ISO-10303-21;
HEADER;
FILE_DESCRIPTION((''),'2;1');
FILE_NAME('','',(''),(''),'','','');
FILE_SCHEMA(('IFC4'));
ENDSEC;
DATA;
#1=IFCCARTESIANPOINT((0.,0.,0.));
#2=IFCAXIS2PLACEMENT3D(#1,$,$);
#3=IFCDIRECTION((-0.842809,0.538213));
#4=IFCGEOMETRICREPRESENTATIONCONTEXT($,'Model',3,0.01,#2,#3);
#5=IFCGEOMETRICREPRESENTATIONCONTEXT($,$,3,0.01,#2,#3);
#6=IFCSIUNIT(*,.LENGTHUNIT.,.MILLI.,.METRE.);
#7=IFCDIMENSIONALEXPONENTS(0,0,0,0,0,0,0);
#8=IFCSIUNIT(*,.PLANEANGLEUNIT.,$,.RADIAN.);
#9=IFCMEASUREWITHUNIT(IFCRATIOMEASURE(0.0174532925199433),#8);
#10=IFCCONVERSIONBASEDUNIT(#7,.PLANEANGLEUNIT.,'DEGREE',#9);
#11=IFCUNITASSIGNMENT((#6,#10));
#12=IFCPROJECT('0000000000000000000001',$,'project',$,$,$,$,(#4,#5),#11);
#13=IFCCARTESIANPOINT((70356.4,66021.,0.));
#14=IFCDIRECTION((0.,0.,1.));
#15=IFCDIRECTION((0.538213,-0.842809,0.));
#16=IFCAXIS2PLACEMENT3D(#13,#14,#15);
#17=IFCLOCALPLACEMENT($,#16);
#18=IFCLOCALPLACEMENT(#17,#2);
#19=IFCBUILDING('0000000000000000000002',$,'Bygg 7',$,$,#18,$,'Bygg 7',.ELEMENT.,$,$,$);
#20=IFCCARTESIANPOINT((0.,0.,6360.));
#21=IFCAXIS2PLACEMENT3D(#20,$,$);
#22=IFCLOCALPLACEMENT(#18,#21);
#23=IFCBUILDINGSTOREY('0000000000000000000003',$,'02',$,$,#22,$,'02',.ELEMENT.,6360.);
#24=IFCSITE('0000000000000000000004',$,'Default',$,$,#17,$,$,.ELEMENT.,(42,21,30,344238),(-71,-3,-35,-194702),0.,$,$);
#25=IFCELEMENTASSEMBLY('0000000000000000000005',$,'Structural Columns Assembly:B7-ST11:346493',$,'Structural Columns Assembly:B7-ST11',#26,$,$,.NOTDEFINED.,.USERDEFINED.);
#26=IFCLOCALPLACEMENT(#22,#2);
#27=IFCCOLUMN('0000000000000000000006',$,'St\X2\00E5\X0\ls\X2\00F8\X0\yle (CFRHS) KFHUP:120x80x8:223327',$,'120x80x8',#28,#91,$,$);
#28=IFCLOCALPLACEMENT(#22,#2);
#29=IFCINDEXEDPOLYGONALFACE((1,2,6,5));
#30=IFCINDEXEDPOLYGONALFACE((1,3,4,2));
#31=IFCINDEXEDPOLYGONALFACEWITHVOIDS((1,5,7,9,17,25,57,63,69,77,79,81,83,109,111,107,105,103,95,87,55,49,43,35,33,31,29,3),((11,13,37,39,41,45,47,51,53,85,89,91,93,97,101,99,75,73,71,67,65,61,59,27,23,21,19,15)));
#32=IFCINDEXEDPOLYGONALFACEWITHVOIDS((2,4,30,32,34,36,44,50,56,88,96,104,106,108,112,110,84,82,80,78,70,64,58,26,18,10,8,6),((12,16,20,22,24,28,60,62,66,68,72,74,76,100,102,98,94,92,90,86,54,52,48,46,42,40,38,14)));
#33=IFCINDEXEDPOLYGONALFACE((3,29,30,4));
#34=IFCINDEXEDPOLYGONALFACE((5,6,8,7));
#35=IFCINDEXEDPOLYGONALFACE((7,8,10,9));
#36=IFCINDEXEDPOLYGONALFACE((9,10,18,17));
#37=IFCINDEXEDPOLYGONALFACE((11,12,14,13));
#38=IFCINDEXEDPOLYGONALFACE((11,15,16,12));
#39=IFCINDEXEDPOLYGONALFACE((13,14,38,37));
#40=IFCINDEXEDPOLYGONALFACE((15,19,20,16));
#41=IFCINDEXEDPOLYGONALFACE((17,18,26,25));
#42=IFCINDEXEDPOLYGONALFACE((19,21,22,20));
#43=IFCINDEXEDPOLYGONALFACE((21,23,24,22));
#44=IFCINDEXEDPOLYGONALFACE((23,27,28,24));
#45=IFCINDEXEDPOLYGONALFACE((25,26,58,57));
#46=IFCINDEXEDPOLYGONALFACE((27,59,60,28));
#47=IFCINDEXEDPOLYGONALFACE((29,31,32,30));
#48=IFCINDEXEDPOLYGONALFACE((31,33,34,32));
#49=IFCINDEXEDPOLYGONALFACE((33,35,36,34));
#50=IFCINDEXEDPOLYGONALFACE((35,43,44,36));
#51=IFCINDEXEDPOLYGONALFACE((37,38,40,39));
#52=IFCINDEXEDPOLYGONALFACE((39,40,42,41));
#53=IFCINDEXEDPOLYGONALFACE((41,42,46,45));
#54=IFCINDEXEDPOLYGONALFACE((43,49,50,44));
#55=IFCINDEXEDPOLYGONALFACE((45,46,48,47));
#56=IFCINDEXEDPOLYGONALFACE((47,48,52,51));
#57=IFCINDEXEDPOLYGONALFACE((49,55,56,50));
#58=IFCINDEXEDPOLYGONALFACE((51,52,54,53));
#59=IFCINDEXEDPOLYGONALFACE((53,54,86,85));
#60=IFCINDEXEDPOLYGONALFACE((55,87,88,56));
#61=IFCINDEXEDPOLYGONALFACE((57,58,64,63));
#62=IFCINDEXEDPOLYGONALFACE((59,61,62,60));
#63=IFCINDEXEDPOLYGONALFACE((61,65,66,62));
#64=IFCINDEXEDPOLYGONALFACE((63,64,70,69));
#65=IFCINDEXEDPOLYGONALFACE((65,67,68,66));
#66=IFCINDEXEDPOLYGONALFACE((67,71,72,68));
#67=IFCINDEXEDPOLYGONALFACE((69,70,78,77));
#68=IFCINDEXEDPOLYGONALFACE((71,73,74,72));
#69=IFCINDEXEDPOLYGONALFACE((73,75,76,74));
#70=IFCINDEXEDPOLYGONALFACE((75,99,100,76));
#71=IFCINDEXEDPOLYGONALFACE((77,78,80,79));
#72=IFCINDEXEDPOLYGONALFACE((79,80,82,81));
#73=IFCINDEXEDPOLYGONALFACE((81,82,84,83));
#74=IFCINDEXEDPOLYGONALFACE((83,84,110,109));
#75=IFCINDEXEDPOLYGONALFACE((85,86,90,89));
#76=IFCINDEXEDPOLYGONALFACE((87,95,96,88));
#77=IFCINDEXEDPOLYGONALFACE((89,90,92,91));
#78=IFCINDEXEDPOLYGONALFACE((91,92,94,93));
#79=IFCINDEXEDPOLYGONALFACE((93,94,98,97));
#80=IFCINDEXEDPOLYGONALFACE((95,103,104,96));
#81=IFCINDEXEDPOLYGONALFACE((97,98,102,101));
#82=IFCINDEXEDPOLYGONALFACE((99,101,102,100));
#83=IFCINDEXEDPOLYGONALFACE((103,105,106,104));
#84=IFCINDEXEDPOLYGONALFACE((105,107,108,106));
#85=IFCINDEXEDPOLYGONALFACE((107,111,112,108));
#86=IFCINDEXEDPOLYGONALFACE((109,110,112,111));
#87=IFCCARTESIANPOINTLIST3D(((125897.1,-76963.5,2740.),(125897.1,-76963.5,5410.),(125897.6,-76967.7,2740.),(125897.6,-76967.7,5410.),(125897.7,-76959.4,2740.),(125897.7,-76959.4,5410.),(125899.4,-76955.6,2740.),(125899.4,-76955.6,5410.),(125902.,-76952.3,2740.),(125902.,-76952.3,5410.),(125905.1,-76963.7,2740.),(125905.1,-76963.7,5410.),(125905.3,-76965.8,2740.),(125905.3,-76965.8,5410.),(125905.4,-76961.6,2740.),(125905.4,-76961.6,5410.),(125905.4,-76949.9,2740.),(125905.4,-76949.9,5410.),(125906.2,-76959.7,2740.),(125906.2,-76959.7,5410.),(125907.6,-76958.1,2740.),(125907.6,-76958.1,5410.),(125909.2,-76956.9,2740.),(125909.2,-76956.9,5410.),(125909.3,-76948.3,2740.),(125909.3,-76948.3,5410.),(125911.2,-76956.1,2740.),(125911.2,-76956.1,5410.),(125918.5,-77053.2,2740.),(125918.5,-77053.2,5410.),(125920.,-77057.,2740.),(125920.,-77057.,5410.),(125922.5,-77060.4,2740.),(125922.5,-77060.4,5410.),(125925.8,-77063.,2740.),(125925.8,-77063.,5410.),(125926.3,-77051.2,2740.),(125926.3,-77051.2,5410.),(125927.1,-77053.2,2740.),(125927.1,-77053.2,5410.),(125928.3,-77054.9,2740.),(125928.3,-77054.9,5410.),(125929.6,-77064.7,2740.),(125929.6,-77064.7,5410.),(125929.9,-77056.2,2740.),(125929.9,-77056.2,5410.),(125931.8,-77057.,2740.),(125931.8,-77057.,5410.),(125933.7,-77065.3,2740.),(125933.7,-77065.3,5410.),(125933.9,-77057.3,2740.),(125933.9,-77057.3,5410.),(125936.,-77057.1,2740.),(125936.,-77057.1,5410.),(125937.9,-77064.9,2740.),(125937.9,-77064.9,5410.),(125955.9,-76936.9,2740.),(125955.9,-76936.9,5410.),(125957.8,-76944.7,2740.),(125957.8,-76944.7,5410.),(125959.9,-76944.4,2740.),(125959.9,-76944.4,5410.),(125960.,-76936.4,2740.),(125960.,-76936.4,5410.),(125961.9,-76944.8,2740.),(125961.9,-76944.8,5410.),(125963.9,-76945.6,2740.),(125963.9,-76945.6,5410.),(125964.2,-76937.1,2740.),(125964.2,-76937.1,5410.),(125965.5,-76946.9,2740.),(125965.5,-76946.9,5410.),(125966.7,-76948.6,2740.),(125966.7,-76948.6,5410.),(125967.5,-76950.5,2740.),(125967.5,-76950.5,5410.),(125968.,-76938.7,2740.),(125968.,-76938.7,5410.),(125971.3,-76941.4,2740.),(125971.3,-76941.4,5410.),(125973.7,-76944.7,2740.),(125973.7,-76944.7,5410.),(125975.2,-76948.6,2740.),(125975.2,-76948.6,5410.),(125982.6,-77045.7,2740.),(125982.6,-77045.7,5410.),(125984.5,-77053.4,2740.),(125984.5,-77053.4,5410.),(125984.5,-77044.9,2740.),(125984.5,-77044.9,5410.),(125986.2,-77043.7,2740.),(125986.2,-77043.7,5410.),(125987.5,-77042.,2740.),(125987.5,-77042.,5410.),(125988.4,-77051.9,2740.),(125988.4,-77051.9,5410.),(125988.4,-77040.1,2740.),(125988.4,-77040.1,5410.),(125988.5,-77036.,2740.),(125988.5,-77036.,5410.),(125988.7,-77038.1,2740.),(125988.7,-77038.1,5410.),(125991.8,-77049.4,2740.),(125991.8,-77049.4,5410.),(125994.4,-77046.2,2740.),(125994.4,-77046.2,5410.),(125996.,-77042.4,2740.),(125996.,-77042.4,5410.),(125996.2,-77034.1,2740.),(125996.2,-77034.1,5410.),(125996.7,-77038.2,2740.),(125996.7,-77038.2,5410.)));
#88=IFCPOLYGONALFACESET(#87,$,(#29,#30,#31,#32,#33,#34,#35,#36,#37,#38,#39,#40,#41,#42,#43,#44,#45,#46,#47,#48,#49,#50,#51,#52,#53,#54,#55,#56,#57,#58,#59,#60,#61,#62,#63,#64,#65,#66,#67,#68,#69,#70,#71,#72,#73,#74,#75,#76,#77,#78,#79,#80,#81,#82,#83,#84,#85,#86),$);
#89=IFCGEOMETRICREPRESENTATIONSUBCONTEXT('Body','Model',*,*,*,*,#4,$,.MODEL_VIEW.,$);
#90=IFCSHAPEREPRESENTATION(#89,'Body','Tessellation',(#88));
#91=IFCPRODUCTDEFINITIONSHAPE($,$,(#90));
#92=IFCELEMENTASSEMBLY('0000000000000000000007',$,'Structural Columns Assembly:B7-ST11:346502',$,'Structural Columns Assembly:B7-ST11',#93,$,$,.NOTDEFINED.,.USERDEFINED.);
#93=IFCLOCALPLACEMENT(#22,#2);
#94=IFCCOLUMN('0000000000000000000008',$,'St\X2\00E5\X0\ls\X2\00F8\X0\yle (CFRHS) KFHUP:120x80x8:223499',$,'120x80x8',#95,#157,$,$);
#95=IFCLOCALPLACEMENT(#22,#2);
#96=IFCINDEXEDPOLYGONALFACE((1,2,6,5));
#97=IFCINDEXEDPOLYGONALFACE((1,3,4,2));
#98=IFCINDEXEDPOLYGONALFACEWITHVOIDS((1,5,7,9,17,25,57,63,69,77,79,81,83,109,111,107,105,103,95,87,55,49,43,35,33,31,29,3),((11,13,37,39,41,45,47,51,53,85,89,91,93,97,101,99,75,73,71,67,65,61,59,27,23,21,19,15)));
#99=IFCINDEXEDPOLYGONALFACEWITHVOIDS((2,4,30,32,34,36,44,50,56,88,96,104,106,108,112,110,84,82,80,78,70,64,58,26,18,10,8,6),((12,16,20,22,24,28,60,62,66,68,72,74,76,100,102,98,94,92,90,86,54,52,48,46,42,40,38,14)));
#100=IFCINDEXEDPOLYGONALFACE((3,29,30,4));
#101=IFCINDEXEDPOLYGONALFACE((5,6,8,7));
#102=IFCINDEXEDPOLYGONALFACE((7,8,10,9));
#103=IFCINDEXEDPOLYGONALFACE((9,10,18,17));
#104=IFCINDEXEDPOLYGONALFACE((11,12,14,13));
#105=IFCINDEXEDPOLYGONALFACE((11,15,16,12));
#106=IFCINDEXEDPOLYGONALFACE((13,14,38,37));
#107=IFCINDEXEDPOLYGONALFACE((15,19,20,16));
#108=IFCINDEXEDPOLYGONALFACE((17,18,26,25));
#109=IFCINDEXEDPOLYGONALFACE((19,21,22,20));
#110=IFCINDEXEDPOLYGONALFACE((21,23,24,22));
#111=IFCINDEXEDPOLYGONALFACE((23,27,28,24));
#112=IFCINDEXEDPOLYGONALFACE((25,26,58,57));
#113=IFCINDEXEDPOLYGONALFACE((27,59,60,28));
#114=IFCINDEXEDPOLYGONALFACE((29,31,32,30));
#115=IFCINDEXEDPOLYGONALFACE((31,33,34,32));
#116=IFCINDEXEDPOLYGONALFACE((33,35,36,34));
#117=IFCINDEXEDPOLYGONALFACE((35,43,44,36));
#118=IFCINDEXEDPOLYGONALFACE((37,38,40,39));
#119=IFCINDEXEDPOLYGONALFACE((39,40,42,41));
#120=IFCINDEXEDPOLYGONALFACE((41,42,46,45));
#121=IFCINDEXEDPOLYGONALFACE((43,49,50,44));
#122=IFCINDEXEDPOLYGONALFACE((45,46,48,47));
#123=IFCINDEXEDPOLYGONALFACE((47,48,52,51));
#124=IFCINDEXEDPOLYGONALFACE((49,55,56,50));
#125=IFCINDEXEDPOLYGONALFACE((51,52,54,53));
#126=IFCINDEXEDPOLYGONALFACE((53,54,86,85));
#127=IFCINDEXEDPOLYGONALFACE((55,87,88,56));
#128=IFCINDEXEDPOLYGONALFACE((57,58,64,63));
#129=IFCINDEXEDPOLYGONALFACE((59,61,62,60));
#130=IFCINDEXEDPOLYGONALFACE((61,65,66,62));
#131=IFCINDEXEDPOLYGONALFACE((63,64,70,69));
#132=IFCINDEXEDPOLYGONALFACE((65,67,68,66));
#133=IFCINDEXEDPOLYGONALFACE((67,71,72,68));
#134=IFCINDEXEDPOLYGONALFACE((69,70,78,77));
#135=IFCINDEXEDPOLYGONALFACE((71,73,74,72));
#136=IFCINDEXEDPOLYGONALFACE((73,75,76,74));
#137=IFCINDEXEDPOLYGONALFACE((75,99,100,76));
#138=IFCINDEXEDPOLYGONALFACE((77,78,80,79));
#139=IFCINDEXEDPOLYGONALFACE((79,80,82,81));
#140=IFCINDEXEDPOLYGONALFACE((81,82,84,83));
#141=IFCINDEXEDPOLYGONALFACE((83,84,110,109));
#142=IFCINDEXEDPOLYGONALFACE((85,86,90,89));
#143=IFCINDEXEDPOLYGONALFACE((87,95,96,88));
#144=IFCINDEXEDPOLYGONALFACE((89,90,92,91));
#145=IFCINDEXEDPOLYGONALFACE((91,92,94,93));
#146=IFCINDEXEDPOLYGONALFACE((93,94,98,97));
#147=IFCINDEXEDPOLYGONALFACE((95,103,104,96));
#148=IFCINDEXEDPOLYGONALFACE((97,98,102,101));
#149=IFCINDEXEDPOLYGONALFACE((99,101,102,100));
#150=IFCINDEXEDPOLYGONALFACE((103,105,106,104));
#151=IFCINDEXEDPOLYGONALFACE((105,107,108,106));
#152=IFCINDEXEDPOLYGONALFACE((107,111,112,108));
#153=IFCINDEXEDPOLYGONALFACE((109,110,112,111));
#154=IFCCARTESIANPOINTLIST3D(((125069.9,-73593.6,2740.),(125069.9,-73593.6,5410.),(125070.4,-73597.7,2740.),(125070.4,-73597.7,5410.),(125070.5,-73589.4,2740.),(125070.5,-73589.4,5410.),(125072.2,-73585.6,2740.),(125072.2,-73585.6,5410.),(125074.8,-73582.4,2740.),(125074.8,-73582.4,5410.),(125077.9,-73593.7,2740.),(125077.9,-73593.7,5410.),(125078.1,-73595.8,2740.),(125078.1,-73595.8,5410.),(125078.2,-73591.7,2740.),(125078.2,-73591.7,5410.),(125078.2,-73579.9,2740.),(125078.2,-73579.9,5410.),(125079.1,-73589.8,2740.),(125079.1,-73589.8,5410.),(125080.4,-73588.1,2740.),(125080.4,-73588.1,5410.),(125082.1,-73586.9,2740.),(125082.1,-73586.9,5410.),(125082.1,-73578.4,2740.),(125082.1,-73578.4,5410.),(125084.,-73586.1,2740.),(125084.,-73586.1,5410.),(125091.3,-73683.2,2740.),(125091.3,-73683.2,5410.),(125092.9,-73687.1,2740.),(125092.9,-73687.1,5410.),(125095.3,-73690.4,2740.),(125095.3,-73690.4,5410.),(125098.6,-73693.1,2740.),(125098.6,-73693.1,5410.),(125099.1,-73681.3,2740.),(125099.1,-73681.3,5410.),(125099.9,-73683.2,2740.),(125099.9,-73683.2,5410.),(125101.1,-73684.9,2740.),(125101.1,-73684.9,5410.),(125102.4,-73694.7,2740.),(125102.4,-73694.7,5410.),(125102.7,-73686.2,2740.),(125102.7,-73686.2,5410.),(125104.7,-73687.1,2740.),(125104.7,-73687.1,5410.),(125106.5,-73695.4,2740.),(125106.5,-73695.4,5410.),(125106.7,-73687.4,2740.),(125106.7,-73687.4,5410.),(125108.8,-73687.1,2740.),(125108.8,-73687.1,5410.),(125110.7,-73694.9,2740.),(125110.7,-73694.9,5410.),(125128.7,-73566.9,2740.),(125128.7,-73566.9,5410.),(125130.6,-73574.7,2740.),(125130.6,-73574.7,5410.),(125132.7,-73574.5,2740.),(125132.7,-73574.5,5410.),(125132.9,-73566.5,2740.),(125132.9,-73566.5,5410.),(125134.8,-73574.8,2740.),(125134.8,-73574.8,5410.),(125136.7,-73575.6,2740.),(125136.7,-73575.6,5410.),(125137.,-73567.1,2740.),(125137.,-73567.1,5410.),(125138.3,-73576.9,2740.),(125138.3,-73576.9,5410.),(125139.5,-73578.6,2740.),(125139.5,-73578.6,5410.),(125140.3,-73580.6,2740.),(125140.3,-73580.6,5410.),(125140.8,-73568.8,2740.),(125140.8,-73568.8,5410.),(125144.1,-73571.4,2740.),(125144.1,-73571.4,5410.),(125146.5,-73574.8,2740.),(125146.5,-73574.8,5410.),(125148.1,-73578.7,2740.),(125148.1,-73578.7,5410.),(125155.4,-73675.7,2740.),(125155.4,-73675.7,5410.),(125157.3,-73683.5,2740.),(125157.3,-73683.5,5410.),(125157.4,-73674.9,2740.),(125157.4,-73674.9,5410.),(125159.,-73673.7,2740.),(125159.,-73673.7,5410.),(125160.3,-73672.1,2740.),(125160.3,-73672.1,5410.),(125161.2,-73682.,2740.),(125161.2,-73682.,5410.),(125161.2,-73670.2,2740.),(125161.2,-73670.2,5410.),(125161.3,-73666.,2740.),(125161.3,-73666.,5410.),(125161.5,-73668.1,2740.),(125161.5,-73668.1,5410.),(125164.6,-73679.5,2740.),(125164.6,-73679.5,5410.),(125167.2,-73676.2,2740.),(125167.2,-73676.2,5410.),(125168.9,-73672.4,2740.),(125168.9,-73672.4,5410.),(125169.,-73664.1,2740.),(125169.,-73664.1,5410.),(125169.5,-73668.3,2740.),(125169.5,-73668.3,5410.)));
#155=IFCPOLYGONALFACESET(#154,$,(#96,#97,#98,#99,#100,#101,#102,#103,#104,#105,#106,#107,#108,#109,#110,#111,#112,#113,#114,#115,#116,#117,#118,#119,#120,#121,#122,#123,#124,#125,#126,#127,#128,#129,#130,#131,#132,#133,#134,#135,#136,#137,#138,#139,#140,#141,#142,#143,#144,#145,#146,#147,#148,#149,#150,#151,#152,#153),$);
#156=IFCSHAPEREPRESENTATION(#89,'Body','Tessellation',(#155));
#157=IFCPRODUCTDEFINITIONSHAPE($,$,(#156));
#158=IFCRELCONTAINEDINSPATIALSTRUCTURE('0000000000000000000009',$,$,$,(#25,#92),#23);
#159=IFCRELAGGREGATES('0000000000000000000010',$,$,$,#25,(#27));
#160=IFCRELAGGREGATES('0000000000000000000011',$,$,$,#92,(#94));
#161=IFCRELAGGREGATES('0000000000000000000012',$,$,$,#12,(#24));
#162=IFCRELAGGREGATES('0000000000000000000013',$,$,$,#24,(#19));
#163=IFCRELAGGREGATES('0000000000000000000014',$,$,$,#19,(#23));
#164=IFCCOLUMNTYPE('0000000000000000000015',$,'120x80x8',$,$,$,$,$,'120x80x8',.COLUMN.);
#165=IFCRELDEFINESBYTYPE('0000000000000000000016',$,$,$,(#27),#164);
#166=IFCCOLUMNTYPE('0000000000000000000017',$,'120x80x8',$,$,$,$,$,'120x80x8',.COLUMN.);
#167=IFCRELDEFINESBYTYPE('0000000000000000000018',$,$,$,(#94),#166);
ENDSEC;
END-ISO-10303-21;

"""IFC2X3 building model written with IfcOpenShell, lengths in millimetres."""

from ifc_helpers import new_model, entity, si_unit, converted_unit, direction, frame, frame_2d, origin, place, context, subcontext, project, spatial, polyline, circle_curve, parameter, trimmed, segment, composite_curve, outline, extrude, source, transform, mapped, type_object, type_shapes, element, aggregate, save


model = new_model("IFC2X3")

# Units and contexts
model_context = context("Model", 3, precision=0.01, world=origin(), true_north=direction((-0.842809, 0.538213)))
context_of_model = context(None, 3, precision=0.01, world=origin(), true_north=direction((-0.842809, 0.538213)))
body_context = subcontext(model_context, "Body", "Model", "MODEL_VIEW")
ifc_project = project(units=[si_unit("LENGTHUNIT", "METRE", prefix="MILLI"), converted_unit("PLANEANGLEUNIT", "DEGREE", entity("IfcRatioMeasure", 0.0174532925199433), si_unit("PLANEANGLEUNIT", "RADIAN"), dimensions=[0, 0, 0, 0, 0, 0, 0])], contexts=[model_context, context_of_model])

# Site, building, storey
site_placement = place(None, frame((70356.4, 66021.0, 0.0), z_axis=(0.0, 0.0, 1.0), x_axis=(0.538213, -0.842809, 0.0)))
site = spatial("IfcSite", under=ifc_project, at=site_placement, Name="Default", CompositionType="ELEMENT", RefLatitude=(42, 21, 30, 344238), RefLongitude=(-71, -3, -35, -194702), RefElevation=0.0)
building_placement = place(site_placement, origin())
building = spatial("IfcBuilding", under=site, at=building_placement, Name="Bygg 7", LongName="Bygg 7", CompositionType="ELEMENT")
storey_placement = place(building_placement, frame((0.0, 0.0, 6360.0)))
storey = spatial("IfcBuildingStorey", under=building, at=storey_placement, Name="02", LongName="02", CompositionType="ELEMENT", Elevation=6360.0)

# Element assemblies, columns
assembly_1_placement = place(storey_placement, origin())
assembly_1 = element("IfcElementAssembly", 1, at=assembly_1_placement, inside=storey, Name="Structural Columns Assembly:B7-ST11:346493", ObjectType="Structural Columns Assembly:B7-ST11", AssemblyPlace="NOTDEFINED", PredefinedType="USERDEFINED")
column_type_1 = type_object("IfcColumnType", Name="120x80x8", ElementType="120x80x8", PredefinedType="COLUMN")
shared_shape_1 = source(origin(), body_context, "Body", "SweptSolid", [
    extrude(outline(composite_curve([segment(trimmed(circle_curve(frame_2d((-24.0, 44.0), x_axis=(1.0, 0.0)), 16.0), [parameter(90.0)], [parameter(180.0)], True, "PARAMETER"), True, "CONTINUOUS"), segment(polyline([(-40.0, 44.0), (-40.0, -44.0)]), True, "CONTINUOUS"), segment(trimmed(circle_curve(frame_2d((-24.0, -44.0), x_axis=(1.0, 0.0)), 16.0), [parameter(180.0)], [parameter(270.0)], True, "PARAMETER"), True, "CONTINUOUS"), segment(polyline([(-24.0, -60.0), (24.0, -60.0)]), True, "CONTINUOUS"), segment(trimmed(circle_curve(frame_2d((24.0, -44.0), x_axis=(1.0, 0.0)), 16.0), [parameter(270.0)], [parameter(0.0)], True, "PARAMETER"), True, "CONTINUOUS"), segment(polyline([(40.0, -44.0), (40.0, 44.0)]), True, "CONTINUOUS"), segment(trimmed(circle_curve(frame_2d((24.0, 44.0), x_axis=(1.0, 0.0)), 16.0), [parameter(0.0)], [parameter(90.0)], True, "PARAMETER"), True, "CONTINUOUS"), segment(polyline([(24.0, 60.0), (-24.0, 60.0)]), True, "CONTINUOUS")], self_intersect=False), holes=[composite_curve([segment(polyline([(-24.0, 52.0), (24.0, 52.0)]), True, "CONTINUOUS"), segment(trimmed(circle_curve(frame_2d((24.0, 44.0), x_axis=(1.0, 0.0)), 8.0), [parameter(360.0)], [parameter(90.0)], True, "PARAMETER"), False, "CONTINUOUS"), segment(polyline([(32.0, 44.0), (32.0, -44.0)]), True, "CONTINUOUS"), segment(trimmed(circle_curve(frame_2d((24.0, -44.0), x_axis=(1.0, 0.0)), 8.0), [parameter(270.0)], [parameter(360.0)], True, "PARAMETER"), False, "CONTINUOUS"), segment(polyline([(24.0, -52.0), (-24.0, -52.0)]), True, "CONTINUOUS"), segment(trimmed(circle_curve(frame_2d((-24.0, -44.0), x_axis=(1.0, 0.0)), 8.0), [parameter(180.0)], [parameter(270.0)], True, "PARAMETER"), False, "CONTINUOUS"), segment(polyline([(-32.0, -44.0), (-32.0, 44.0)]), True, "CONTINUOUS"), segment(trimmed(circle_curve(frame_2d((-24.0, 44.0), x_axis=(1.0, 0.0)), 8.0), [parameter(90.0)], [parameter(180.0)], True, "PARAMETER"), False, "CONTINUOUS")], self_intersect=False)]), frame((51.4, 66.0, 0.0), z_axis=(0.0, 0.0, 1.0), x_axis=(-0.971172, -0.238381, 0.0)), (0.0, 0.0, 1.0), 2670.0),
])
type_shapes(column_type_1, [shared_shape_1])
column_1_placement = place(assembly_1_placement, frame((125895.5, -77066.9, 2740.0)))
column_1 = element("IfcColumn", 2, at=column_1_placement, type_object=column_type_1, Name="Stålsøyle (CFRHS) KFHUP:120x80x8:223327", ObjectType="120x80x8", context=body_context, shape_type="MappedRepresentation", body=[
    mapped(shared_shape_1, transform((0.0, 0.0, 0.0), scale=1.0)),
])
aggregate(assembly_1, [column_1])
assembly_2_placement = place(storey_placement, origin())
assembly_2 = element("IfcElementAssembly", 3, at=assembly_2_placement, inside=storey, Name="Structural Columns Assembly:B7-ST11:346502", ObjectType="Structural Columns Assembly:B7-ST11", AssemblyPlace="NOTDEFINED", PredefinedType="USERDEFINED")
column_type_2 = type_object("IfcColumnType", Name="120x80x8", ElementType="120x80x8", PredefinedType="COLUMN")
shared_shape_2 = source(origin(), body_context, "Body", "SweptSolid", [
    extrude(outline(composite_curve([segment(trimmed(circle_curve(frame_2d((-24.0, 44.0), x_axis=(1.0, 0.0)), 16.0), [parameter(90.0)], [parameter(180.0)], True, "PARAMETER"), True, "CONTINUOUS"), segment(polyline([(-40.0, 44.0), (-40.0, -44.0)]), True, "CONTINUOUS"), segment(trimmed(circle_curve(frame_2d((-24.0, -44.0), x_axis=(1.0, 0.0)), 16.0), [parameter(180.0)], [parameter(270.0)], True, "PARAMETER"), True, "CONTINUOUS"), segment(polyline([(-24.0, -60.0), (24.0, -60.0)]), True, "CONTINUOUS"), segment(trimmed(circle_curve(frame_2d((24.0, -44.0), x_axis=(1.0, 0.0)), 16.0), [parameter(270.0)], [parameter(0.0)], True, "PARAMETER"), True, "CONTINUOUS"), segment(polyline([(40.0, -44.0), (40.0, 44.0)]), True, "CONTINUOUS"), segment(trimmed(circle_curve(frame_2d((24.0, 44.0), x_axis=(1.0, 0.0)), 16.0), [parameter(0.0)], [parameter(90.0)], True, "PARAMETER"), True, "CONTINUOUS"), segment(polyline([(24.0, 60.0), (-24.0, 60.0)]), True, "CONTINUOUS")], self_intersect=False), holes=[composite_curve([segment(polyline([(-24.0, 52.0), (24.0, 52.0)]), True, "CONTINUOUS"), segment(trimmed(circle_curve(frame_2d((24.0, 44.0), x_axis=(1.0, 0.0)), 8.0), [parameter(360.0)], [parameter(90.0)], True, "PARAMETER"), False, "CONTINUOUS"), segment(polyline([(32.0, 44.0), (32.0, -44.0)]), True, "CONTINUOUS"), segment(trimmed(circle_curve(frame_2d((24.0, -44.0), x_axis=(1.0, 0.0)), 8.0), [parameter(270.0)], [parameter(360.0)], True, "PARAMETER"), False, "CONTINUOUS"), segment(polyline([(24.0, -52.0), (-24.0, -52.0)]), True, "CONTINUOUS"), segment(trimmed(circle_curve(frame_2d((-24.0, -44.0), x_axis=(1.0, 0.0)), 8.0), [parameter(180.0)], [parameter(270.0)], True, "PARAMETER"), False, "CONTINUOUS"), segment(polyline([(-32.0, -44.0), (-32.0, 44.0)]), True, "CONTINUOUS"), segment(trimmed(circle_curve(frame_2d((-24.0, 44.0), x_axis=(1.0, 0.0)), 8.0), [parameter(90.0)], [parameter(180.0)], True, "PARAMETER"), False, "CONTINUOUS")], self_intersect=False)]), frame((51.4, 66.0, 0.0), z_axis=(0.0, 0.0, 1.0), x_axis=(-0.971172, -0.238381, 0.0)), (0.0, 0.0, 1.0), 2670.0),
])
type_shapes(column_type_2, [shared_shape_2])
column_2_placement = place(assembly_2_placement, frame((125068.3, -73697.0, 2740.0)))
column_2 = element("IfcColumn", 4, at=column_2_placement, type_object=column_type_2, Name="Stålsøyle (CFRHS) KFHUP:120x80x8:223499", ObjectType="120x80x8", context=body_context, shape_type="MappedRepresentation", body=[
    mapped(shared_shape_2, transform((0.0, 0.0, 0.0), scale=1.0)),
])
aggregate(assembly_2, [column_2])

save(model, "model.ifc")
